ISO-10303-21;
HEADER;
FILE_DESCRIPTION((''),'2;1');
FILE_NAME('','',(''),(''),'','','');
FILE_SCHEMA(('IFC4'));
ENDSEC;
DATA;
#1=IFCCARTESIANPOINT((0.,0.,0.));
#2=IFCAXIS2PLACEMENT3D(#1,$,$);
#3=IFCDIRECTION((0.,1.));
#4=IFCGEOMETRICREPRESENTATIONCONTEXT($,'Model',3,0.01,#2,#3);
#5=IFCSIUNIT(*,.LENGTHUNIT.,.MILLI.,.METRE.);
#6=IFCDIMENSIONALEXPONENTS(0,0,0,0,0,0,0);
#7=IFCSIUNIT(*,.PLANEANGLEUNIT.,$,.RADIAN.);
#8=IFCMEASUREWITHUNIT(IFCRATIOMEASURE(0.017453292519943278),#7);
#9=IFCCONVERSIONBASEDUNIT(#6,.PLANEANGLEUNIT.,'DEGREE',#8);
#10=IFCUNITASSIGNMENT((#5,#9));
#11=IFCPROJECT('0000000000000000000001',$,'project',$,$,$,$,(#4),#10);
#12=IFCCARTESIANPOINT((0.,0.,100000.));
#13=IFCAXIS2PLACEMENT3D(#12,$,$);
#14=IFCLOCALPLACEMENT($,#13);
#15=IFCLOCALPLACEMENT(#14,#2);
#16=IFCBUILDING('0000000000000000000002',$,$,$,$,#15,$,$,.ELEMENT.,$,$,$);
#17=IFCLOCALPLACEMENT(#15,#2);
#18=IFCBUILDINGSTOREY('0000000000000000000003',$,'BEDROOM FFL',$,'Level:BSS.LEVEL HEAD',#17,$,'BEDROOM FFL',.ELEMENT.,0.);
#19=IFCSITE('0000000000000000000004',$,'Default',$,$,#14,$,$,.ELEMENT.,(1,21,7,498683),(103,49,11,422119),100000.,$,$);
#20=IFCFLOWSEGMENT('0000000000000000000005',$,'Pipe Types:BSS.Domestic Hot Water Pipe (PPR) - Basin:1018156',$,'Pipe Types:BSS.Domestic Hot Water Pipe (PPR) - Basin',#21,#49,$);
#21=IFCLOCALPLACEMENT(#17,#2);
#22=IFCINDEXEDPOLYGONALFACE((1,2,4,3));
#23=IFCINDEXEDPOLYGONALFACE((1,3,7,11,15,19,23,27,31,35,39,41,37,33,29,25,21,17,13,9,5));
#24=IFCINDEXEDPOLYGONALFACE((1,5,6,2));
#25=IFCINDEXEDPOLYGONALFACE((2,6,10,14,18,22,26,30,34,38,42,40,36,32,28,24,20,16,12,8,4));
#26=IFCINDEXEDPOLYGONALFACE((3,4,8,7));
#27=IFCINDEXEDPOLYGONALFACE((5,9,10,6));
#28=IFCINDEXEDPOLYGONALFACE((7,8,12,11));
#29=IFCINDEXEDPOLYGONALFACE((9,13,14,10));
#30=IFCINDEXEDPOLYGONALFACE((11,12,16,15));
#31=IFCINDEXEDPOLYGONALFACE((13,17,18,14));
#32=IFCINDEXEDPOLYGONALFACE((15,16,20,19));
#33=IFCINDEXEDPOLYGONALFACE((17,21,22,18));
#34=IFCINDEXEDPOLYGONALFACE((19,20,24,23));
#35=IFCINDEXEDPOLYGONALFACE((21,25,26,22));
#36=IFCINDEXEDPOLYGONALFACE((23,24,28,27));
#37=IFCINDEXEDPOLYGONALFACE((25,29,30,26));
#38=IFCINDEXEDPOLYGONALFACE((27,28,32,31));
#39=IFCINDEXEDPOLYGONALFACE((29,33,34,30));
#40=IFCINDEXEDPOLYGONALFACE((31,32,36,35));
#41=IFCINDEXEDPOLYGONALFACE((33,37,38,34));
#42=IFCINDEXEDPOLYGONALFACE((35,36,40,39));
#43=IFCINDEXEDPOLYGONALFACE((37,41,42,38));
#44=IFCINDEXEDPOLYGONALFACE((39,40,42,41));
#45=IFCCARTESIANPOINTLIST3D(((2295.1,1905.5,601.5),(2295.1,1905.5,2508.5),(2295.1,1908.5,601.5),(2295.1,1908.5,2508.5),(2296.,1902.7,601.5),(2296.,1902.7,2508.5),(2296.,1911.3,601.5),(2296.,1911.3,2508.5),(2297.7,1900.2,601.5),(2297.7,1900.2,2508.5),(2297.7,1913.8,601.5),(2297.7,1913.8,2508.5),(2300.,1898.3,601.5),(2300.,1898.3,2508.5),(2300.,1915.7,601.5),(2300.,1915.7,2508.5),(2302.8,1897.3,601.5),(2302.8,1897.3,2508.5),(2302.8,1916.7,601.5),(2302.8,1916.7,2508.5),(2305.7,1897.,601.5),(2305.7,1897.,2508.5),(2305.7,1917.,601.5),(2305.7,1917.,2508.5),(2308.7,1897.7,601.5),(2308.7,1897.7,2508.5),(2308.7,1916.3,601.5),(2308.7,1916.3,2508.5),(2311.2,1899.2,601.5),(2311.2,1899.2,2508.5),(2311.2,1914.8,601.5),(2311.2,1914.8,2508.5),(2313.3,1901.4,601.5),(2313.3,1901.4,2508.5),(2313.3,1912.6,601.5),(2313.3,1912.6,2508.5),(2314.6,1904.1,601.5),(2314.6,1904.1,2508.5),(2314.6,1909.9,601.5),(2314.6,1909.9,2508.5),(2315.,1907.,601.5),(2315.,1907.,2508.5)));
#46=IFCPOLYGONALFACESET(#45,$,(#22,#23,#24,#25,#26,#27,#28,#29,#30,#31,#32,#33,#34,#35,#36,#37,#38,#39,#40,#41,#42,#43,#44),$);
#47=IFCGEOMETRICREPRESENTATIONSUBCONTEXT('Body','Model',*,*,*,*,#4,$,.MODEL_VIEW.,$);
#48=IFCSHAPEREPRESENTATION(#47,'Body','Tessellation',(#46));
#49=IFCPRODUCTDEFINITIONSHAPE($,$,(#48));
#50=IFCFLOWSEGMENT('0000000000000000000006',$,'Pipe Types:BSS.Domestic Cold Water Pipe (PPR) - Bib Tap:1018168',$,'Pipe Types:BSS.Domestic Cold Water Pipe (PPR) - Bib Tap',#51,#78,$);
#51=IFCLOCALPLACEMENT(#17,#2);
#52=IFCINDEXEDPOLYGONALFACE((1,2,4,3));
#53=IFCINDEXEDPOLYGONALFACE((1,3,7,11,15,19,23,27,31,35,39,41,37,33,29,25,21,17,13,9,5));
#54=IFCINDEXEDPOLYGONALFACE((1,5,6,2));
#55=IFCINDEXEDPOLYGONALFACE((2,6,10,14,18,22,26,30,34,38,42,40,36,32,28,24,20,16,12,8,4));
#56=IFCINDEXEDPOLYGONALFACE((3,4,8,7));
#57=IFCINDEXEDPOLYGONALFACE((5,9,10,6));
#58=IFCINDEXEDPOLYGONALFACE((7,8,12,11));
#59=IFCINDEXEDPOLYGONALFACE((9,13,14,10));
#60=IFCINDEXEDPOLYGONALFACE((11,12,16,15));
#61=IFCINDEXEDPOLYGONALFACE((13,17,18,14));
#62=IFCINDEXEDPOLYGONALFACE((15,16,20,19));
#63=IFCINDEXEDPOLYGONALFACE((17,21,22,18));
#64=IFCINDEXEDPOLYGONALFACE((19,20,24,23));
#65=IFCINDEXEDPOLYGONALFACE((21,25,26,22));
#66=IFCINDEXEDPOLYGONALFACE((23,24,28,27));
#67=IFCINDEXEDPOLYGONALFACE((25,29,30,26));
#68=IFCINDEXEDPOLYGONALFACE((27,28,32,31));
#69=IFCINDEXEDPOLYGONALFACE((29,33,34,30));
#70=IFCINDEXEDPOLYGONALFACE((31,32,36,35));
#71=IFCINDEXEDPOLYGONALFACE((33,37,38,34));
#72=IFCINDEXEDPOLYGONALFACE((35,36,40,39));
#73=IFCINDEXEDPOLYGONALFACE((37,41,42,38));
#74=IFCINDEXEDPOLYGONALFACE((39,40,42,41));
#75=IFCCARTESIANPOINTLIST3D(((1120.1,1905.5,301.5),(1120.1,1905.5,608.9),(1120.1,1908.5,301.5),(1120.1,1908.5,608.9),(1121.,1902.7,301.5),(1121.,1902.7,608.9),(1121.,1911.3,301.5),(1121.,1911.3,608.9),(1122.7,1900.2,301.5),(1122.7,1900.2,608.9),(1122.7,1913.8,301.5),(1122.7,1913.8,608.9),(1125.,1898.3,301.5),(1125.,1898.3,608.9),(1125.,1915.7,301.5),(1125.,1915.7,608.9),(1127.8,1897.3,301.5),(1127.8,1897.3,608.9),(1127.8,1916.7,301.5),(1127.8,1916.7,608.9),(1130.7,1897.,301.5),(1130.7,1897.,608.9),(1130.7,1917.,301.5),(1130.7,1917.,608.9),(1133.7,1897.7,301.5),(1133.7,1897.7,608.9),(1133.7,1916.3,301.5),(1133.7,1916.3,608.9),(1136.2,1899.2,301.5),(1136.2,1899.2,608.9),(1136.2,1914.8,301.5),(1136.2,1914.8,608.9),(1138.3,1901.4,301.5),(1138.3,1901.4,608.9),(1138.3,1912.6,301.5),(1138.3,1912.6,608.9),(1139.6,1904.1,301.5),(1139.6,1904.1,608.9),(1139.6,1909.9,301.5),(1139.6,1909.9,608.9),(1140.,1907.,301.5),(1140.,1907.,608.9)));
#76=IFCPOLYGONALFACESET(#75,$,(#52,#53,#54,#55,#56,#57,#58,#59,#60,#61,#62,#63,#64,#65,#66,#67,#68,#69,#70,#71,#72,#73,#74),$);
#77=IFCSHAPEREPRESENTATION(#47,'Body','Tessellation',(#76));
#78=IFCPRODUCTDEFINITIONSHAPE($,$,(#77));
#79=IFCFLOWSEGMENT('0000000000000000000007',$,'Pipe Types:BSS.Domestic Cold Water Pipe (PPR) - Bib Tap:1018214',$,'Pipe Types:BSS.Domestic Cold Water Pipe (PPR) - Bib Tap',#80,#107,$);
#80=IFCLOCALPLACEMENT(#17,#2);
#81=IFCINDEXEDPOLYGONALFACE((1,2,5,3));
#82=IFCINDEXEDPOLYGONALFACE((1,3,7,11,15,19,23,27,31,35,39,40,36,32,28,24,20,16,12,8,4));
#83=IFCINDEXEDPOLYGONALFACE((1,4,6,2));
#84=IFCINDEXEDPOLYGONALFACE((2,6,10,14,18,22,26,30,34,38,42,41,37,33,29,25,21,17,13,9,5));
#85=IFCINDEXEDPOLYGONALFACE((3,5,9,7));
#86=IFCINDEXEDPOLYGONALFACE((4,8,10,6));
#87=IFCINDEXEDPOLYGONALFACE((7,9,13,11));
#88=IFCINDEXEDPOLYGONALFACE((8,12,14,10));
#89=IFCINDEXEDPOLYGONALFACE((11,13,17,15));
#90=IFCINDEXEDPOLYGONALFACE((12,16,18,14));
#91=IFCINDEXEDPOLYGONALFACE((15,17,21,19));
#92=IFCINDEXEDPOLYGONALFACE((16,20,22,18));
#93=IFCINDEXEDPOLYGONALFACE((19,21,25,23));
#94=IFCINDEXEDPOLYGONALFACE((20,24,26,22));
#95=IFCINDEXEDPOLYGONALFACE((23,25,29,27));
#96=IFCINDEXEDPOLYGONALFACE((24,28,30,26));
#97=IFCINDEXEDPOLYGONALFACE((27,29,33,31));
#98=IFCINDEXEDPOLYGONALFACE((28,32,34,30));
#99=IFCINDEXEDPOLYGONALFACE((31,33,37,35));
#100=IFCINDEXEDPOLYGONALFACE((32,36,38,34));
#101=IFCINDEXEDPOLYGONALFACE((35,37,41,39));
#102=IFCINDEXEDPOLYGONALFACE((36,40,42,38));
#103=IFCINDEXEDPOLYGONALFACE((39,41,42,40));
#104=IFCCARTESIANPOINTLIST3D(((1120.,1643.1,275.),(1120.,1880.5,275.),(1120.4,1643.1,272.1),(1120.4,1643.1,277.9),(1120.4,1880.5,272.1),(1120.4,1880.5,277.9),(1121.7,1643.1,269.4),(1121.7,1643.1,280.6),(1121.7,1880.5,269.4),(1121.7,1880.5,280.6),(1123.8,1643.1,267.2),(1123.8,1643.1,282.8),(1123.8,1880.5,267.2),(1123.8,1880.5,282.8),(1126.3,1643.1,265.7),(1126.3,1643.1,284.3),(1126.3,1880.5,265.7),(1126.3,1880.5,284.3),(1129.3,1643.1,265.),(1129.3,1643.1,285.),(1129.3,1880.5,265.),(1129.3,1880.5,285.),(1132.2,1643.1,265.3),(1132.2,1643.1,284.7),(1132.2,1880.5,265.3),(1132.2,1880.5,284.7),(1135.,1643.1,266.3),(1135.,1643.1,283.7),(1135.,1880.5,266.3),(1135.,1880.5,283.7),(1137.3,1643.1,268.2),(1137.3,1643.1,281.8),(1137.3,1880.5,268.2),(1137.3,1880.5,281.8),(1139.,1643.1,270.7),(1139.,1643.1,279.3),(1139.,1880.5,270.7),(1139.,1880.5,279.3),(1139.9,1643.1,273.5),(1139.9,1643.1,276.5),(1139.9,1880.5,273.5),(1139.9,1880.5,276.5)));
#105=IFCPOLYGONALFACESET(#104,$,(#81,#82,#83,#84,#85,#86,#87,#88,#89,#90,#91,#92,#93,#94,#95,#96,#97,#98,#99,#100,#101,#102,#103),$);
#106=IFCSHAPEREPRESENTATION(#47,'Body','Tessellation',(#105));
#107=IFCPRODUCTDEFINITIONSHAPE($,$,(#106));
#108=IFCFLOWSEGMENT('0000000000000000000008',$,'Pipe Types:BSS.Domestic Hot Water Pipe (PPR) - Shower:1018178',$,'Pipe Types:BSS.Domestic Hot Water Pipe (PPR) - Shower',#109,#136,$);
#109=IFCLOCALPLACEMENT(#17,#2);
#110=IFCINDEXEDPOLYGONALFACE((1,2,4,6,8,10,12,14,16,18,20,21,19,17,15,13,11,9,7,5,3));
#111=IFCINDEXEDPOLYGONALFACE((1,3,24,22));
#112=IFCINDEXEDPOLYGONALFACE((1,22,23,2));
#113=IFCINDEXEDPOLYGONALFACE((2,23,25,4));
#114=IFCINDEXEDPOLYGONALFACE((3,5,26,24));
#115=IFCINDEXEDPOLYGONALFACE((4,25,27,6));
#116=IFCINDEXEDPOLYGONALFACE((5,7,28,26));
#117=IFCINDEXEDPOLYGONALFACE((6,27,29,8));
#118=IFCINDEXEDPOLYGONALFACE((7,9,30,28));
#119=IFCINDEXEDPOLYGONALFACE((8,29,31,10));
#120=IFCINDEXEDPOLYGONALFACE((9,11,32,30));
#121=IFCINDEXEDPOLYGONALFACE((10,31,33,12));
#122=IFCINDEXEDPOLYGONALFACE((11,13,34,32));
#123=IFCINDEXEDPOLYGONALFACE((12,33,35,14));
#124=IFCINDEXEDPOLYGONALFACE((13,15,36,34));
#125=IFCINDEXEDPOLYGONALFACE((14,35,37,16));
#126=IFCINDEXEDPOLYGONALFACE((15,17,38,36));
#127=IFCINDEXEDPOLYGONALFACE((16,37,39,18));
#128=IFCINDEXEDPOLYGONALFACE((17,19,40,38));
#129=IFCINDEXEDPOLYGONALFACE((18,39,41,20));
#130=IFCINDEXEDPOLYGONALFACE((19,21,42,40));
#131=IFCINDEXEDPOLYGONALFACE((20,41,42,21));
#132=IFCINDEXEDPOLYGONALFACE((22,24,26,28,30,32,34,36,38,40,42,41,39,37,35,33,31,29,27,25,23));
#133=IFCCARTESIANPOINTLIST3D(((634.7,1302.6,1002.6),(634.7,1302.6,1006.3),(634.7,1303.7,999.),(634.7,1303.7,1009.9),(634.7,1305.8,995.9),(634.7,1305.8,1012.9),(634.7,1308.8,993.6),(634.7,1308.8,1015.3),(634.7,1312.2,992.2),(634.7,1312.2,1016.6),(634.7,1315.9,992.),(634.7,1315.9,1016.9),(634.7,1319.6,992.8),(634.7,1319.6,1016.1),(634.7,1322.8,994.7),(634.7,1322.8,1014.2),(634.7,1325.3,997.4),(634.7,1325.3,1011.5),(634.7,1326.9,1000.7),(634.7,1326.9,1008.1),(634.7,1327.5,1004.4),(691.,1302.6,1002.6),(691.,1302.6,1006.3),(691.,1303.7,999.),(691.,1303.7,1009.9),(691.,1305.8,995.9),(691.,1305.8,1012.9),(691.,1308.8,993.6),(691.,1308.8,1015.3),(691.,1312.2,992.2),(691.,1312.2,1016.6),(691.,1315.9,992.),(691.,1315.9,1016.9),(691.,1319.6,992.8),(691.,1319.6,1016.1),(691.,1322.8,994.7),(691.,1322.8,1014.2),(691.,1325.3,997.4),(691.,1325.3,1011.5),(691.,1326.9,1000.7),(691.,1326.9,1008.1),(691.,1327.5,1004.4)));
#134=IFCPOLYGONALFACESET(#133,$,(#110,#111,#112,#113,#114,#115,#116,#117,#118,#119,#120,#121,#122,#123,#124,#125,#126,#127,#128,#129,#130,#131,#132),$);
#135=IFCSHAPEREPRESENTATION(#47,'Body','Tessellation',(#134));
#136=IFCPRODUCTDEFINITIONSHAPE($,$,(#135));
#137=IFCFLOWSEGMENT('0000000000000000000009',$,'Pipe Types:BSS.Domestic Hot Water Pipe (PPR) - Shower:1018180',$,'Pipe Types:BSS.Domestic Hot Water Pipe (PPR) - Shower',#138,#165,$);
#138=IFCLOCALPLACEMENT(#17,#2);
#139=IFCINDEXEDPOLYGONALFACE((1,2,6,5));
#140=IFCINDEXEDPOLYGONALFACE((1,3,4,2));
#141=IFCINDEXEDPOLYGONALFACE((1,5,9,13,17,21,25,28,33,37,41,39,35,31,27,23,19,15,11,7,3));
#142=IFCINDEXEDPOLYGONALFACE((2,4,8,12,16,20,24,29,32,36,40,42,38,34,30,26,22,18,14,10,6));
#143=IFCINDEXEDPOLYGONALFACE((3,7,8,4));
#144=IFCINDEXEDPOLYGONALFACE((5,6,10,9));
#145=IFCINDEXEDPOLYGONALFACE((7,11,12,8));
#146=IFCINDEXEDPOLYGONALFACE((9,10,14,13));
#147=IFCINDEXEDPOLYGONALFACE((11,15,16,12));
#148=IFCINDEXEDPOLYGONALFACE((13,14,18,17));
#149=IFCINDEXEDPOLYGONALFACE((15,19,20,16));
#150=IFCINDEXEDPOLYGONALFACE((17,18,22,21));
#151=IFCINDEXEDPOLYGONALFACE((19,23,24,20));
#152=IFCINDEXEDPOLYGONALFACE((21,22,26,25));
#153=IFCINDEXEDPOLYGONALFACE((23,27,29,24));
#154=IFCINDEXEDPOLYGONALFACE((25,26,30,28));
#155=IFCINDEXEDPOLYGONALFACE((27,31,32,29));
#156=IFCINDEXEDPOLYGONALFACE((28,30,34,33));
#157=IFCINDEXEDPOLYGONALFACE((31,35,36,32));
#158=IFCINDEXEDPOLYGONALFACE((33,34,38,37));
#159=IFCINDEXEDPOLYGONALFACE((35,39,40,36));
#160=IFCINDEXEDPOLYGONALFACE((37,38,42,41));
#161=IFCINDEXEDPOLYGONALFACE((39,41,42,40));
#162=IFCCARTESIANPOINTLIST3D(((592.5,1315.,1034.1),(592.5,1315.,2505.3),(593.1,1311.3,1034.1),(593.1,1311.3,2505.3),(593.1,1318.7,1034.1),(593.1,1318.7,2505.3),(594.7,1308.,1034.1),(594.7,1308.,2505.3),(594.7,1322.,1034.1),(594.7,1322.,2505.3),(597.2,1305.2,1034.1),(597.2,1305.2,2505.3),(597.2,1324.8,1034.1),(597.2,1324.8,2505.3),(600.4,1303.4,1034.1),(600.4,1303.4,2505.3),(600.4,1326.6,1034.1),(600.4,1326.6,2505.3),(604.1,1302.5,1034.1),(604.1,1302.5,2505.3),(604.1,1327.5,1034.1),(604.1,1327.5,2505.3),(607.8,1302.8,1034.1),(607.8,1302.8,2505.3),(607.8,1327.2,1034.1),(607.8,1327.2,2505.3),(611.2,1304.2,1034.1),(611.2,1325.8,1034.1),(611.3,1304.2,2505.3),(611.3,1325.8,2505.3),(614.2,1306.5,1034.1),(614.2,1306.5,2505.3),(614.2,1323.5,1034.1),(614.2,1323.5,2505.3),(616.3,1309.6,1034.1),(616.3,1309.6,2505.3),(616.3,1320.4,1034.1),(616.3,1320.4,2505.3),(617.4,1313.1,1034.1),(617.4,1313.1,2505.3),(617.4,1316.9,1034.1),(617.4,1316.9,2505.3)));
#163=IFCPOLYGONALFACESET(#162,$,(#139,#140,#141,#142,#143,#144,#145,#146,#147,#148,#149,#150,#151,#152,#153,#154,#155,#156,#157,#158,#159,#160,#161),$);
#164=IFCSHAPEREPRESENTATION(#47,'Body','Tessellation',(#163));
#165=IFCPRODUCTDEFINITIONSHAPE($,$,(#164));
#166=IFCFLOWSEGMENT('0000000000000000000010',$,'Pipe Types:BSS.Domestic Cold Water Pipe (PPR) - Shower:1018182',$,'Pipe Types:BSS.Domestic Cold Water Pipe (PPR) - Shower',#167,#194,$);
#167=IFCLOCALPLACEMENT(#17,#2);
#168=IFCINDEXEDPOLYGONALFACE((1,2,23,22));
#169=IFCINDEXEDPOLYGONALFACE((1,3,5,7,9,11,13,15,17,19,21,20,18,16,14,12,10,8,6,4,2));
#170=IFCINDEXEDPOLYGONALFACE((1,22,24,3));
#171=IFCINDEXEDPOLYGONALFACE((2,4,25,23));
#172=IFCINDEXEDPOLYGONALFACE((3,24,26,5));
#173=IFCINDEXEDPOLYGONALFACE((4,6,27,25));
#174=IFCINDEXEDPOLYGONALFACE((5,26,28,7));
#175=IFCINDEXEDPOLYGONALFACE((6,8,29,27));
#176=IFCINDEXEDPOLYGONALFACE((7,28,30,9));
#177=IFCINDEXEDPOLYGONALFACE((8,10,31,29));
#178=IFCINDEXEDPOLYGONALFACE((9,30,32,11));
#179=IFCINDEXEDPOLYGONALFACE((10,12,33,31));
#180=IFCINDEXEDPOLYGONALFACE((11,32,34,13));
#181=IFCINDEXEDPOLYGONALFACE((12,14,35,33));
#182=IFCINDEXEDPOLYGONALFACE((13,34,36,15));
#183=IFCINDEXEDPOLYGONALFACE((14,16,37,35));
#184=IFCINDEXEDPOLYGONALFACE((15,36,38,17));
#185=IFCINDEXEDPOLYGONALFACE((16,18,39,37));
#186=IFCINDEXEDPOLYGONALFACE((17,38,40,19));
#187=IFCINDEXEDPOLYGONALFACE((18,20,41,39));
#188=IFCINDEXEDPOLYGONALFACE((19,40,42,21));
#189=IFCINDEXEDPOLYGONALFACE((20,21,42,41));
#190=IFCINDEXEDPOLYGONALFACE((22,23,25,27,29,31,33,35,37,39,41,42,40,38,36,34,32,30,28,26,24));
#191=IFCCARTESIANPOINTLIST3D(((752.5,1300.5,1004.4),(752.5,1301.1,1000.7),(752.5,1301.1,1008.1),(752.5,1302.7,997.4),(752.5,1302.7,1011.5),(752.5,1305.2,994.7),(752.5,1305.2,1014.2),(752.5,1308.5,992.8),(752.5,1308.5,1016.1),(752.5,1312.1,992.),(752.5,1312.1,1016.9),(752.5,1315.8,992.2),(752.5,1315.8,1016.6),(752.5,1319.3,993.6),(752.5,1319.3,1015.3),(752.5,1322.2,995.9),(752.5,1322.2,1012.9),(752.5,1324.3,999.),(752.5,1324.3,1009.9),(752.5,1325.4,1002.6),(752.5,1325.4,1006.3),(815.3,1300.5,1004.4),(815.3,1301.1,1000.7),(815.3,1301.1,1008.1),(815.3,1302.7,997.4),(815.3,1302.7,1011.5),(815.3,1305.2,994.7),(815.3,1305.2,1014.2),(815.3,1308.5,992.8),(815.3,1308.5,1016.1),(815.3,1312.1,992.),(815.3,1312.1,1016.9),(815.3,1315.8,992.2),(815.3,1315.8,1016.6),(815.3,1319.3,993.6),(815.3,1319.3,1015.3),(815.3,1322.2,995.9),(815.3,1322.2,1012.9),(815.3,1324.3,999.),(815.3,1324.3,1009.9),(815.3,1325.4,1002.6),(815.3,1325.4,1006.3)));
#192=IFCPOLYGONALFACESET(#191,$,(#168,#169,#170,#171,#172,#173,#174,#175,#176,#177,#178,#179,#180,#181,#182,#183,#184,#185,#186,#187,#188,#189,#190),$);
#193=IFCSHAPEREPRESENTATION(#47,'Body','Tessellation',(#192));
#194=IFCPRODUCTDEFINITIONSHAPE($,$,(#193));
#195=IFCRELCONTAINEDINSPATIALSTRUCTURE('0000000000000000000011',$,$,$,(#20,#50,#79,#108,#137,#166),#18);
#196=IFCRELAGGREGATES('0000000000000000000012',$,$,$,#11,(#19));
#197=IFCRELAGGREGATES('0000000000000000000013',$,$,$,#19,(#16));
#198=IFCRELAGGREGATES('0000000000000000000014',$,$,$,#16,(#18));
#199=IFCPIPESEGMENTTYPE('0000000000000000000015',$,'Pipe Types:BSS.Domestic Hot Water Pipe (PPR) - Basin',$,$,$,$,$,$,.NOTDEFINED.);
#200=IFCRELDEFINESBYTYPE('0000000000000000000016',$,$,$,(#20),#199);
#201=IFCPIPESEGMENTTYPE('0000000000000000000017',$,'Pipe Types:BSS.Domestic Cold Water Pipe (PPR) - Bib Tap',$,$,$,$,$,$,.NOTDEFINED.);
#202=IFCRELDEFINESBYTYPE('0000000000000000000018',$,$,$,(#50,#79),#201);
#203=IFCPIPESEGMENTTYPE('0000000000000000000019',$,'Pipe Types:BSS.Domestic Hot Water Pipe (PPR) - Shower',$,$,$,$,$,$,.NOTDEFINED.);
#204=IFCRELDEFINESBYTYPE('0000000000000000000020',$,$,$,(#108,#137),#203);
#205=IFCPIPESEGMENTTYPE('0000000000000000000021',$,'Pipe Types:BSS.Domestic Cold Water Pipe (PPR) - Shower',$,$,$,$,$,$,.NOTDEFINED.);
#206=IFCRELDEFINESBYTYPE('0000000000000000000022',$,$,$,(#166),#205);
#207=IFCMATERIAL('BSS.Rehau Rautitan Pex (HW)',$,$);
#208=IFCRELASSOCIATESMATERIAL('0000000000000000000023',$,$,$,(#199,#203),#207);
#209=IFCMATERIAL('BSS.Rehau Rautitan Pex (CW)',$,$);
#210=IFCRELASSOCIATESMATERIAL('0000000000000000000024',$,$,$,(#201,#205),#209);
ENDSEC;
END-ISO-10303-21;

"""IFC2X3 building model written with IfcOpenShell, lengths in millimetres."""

from ifc_helpers import new_model, entity, si_unit, converted_unit, direction, frame, frame_2d, origin, origin_2d_with_axis, place, context, subcontext, project, spatial, circle, extrude, material, type_object, element, save


model = new_model("IFC2X3")

# Units and contexts
model_context = context("Model", 3, precision=0.01, world=origin(), true_north=direction((0.0, 1.0)))
body_context = subcontext(model_context, "Body", "Model", "MODEL_VIEW")
ifc_project = project(units=[si_unit("LENGTHUNIT", "METRE", prefix="MILLI"), converted_unit("PLANEANGLEUNIT", "DEGREE", entity("IfcRatioMeasure", 0.017453292519943278), si_unit("PLANEANGLEUNIT", "RADIAN"), dimensions=[0, 0, 0, 0, 0, 0, 0])], contexts=[model_context])

# Site, building, storey
site_placement = place(None, frame((0.0, 0.0, 100000.0)))
site = spatial("IfcSite", under=ifc_project, at=site_placement, Name="Default", CompositionType="ELEMENT", RefLatitude=(1, 21, 7, 498683), RefLongitude=(103, 49, 11, 422119), RefElevation=100000.0)
building_placement = place(site_placement, origin())
building = spatial("IfcBuilding", under=site, at=building_placement, CompositionType="ELEMENT")
storey_placement = place(building_placement, origin())
storey = spatial("IfcBuildingStorey", under=building, at=storey_placement, Name="BEDROOM FFL", ObjectType="Level:BSS.LEVEL HEAD", LongName="BEDROOM FFL", CompositionType="ELEMENT", Elevation=0.0)

# Flow segments
ifc_material_1 = material(Name="BSS.Rehau Rautitan Pex (HW)")
pipe_segment_type_1 = type_object("IfcPipeSegmentType", Name="Pipe Types:BSS.Domestic Hot Water Pipe (PPR) - Basin", PredefinedType="NOTDEFINED", material=ifc_material_1)
flow_segment_1_placement = place(storey_placement, origin())
element("IfcFlowSegment", 1, at=flow_segment_1_placement, inside=storey, type_object=pipe_segment_type_1, Name="Pipe Types:BSS.Domestic Hot Water Pipe (PPR) - Basin:1018156", ObjectType="Pipe Types:BSS.Domestic Hot Water Pipe (PPR) - Basin", context=body_context, shape_type="SweptSolid", body=[
    extrude(circle(Radius=10.0, at=frame_2d((0.0, 0.0), x_axis=(1.0, 0.0))), frame((2305.0, 1907.0, 601.5)), (0.0, 0.0, 1.0), 1907.0),
])
ifc_material_2 = material(Name="BSS.Rehau Rautitan Pex (CW)")
pipe_segment_type_2 = type_object("IfcPipeSegmentType", Name="Pipe Types:BSS.Domestic Cold Water Pipe (PPR) - Bib Tap", PredefinedType="NOTDEFINED", material=ifc_material_2)
flow_segment_2_placement = place(storey_placement, origin())
element("IfcFlowSegment", 2, at=flow_segment_2_placement, inside=storey, type_object=pipe_segment_type_2, Name="Pipe Types:BSS.Domestic Cold Water Pipe (PPR) - Bib Tap:1018168", ObjectType="Pipe Types:BSS.Domestic Cold Water Pipe (PPR) - Bib Tap", context=body_context, shape_type="SweptSolid", body=[
    extrude(circle(Radius=10.0, at=origin_2d_with_axis()), frame((1130.0, 1907.0, 301.5)), (0.0, 0.0, 1.0), 307.4),
])
flow_segment_3_placement = place(storey_placement, origin())
element("IfcFlowSegment", 3, at=flow_segment_3_placement, inside=storey, type_object=pipe_segment_type_2, Name="Pipe Types:BSS.Domestic Cold Water Pipe (PPR) - Bib Tap:1018214", ObjectType="Pipe Types:BSS.Domestic Cold Water Pipe (PPR) - Bib Tap", context=body_context, shape_type="SweptSolid", body=[
    extrude(circle(Radius=10.0, at=frame_2d((0.0, 0.0), x_axis=(1.0, 0.0))), frame((1130.0, 1643.1, 275.0), z_axis=(0.0, 1.0, 0.0), x_axis=(-1.0, 0.0, 0.0)), (0.0, 0.0, 1.0), 237.4),
])
pipe_segment_type_3 = type_object("IfcPipeSegmentType", Name="Pipe Types:BSS.Domestic Hot Water Pipe (PPR) - Shower", PredefinedType="NOTDEFINED", material=ifc_material_1)
flow_segment_4_placement = place(storey_placement, origin())
element("IfcFlowSegment", 4, at=flow_segment_4_placement, inside=storey, type_object=pipe_segment_type_3, Name="Pipe Types:BSS.Domestic Hot Water Pipe (PPR) - Shower:1018178", ObjectType="Pipe Types:BSS.Domestic Hot Water Pipe (PPR) - Shower", context=body_context, shape_type="SweptSolid", body=[
    extrude(circle(Radius=12.5, at=frame_2d((0.0, 0.0), x_axis=(1.0, 0.0))), frame((634.7, 1315.0, 1004.4), z_axis=(1.0, 0.0, 0.0), x_axis=(0.0, 1.0, 0.0)), (0.0, 0.0, 1.0), 56.3),
])
flow_segment_5_placement = place(storey_placement, origin())
element("IfcFlowSegment", 5, at=flow_segment_5_placement, inside=storey, type_object=pipe_segment_type_3, Name="Pipe Types:BSS.Domestic Hot Water Pipe (PPR) - Shower:1018180", ObjectType="Pipe Types:BSS.Domestic Hot Water Pipe (PPR) - Shower", context=body_context, shape_type="SweptSolid", body=[
    extrude(circle(Radius=12.5, at=origin_2d_with_axis()), frame((605.0, 1315.0, 1034.1), z_axis=(0.000002, 0.0, 1.0), x_axis=(-1.0, 0.0, 0.000002)), (0.0, 0.0, 1.0), 1471.2),
])
pipe_segment_type_4 = type_object("IfcPipeSegmentType", Name="Pipe Types:BSS.Domestic Cold Water Pipe (PPR) - Shower", PredefinedType="NOTDEFINED", material=ifc_material_2)
flow_segment_6_placement = place(storey_placement, origin())
element("IfcFlowSegment", 6, at=flow_segment_6_placement, inside=storey, type_object=pipe_segment_type_4, Name="Pipe Types:BSS.Domestic Cold Water Pipe (PPR) - Shower:1018182", ObjectType="Pipe Types:BSS.Domestic Cold Water Pipe (PPR) - Shower", context=body_context, shape_type="SweptSolid", body=[
    extrude(circle(Radius=12.5, at=origin_2d_with_axis()), frame((752.5, 1313.0, 1004.4), z_axis=(1.0, 0.0, 0.0), x_axis=(0.0, -1.0, 0.0)), (0.0, 0.0, 1.0), 62.8),
])

save(model, "model.ifc")
